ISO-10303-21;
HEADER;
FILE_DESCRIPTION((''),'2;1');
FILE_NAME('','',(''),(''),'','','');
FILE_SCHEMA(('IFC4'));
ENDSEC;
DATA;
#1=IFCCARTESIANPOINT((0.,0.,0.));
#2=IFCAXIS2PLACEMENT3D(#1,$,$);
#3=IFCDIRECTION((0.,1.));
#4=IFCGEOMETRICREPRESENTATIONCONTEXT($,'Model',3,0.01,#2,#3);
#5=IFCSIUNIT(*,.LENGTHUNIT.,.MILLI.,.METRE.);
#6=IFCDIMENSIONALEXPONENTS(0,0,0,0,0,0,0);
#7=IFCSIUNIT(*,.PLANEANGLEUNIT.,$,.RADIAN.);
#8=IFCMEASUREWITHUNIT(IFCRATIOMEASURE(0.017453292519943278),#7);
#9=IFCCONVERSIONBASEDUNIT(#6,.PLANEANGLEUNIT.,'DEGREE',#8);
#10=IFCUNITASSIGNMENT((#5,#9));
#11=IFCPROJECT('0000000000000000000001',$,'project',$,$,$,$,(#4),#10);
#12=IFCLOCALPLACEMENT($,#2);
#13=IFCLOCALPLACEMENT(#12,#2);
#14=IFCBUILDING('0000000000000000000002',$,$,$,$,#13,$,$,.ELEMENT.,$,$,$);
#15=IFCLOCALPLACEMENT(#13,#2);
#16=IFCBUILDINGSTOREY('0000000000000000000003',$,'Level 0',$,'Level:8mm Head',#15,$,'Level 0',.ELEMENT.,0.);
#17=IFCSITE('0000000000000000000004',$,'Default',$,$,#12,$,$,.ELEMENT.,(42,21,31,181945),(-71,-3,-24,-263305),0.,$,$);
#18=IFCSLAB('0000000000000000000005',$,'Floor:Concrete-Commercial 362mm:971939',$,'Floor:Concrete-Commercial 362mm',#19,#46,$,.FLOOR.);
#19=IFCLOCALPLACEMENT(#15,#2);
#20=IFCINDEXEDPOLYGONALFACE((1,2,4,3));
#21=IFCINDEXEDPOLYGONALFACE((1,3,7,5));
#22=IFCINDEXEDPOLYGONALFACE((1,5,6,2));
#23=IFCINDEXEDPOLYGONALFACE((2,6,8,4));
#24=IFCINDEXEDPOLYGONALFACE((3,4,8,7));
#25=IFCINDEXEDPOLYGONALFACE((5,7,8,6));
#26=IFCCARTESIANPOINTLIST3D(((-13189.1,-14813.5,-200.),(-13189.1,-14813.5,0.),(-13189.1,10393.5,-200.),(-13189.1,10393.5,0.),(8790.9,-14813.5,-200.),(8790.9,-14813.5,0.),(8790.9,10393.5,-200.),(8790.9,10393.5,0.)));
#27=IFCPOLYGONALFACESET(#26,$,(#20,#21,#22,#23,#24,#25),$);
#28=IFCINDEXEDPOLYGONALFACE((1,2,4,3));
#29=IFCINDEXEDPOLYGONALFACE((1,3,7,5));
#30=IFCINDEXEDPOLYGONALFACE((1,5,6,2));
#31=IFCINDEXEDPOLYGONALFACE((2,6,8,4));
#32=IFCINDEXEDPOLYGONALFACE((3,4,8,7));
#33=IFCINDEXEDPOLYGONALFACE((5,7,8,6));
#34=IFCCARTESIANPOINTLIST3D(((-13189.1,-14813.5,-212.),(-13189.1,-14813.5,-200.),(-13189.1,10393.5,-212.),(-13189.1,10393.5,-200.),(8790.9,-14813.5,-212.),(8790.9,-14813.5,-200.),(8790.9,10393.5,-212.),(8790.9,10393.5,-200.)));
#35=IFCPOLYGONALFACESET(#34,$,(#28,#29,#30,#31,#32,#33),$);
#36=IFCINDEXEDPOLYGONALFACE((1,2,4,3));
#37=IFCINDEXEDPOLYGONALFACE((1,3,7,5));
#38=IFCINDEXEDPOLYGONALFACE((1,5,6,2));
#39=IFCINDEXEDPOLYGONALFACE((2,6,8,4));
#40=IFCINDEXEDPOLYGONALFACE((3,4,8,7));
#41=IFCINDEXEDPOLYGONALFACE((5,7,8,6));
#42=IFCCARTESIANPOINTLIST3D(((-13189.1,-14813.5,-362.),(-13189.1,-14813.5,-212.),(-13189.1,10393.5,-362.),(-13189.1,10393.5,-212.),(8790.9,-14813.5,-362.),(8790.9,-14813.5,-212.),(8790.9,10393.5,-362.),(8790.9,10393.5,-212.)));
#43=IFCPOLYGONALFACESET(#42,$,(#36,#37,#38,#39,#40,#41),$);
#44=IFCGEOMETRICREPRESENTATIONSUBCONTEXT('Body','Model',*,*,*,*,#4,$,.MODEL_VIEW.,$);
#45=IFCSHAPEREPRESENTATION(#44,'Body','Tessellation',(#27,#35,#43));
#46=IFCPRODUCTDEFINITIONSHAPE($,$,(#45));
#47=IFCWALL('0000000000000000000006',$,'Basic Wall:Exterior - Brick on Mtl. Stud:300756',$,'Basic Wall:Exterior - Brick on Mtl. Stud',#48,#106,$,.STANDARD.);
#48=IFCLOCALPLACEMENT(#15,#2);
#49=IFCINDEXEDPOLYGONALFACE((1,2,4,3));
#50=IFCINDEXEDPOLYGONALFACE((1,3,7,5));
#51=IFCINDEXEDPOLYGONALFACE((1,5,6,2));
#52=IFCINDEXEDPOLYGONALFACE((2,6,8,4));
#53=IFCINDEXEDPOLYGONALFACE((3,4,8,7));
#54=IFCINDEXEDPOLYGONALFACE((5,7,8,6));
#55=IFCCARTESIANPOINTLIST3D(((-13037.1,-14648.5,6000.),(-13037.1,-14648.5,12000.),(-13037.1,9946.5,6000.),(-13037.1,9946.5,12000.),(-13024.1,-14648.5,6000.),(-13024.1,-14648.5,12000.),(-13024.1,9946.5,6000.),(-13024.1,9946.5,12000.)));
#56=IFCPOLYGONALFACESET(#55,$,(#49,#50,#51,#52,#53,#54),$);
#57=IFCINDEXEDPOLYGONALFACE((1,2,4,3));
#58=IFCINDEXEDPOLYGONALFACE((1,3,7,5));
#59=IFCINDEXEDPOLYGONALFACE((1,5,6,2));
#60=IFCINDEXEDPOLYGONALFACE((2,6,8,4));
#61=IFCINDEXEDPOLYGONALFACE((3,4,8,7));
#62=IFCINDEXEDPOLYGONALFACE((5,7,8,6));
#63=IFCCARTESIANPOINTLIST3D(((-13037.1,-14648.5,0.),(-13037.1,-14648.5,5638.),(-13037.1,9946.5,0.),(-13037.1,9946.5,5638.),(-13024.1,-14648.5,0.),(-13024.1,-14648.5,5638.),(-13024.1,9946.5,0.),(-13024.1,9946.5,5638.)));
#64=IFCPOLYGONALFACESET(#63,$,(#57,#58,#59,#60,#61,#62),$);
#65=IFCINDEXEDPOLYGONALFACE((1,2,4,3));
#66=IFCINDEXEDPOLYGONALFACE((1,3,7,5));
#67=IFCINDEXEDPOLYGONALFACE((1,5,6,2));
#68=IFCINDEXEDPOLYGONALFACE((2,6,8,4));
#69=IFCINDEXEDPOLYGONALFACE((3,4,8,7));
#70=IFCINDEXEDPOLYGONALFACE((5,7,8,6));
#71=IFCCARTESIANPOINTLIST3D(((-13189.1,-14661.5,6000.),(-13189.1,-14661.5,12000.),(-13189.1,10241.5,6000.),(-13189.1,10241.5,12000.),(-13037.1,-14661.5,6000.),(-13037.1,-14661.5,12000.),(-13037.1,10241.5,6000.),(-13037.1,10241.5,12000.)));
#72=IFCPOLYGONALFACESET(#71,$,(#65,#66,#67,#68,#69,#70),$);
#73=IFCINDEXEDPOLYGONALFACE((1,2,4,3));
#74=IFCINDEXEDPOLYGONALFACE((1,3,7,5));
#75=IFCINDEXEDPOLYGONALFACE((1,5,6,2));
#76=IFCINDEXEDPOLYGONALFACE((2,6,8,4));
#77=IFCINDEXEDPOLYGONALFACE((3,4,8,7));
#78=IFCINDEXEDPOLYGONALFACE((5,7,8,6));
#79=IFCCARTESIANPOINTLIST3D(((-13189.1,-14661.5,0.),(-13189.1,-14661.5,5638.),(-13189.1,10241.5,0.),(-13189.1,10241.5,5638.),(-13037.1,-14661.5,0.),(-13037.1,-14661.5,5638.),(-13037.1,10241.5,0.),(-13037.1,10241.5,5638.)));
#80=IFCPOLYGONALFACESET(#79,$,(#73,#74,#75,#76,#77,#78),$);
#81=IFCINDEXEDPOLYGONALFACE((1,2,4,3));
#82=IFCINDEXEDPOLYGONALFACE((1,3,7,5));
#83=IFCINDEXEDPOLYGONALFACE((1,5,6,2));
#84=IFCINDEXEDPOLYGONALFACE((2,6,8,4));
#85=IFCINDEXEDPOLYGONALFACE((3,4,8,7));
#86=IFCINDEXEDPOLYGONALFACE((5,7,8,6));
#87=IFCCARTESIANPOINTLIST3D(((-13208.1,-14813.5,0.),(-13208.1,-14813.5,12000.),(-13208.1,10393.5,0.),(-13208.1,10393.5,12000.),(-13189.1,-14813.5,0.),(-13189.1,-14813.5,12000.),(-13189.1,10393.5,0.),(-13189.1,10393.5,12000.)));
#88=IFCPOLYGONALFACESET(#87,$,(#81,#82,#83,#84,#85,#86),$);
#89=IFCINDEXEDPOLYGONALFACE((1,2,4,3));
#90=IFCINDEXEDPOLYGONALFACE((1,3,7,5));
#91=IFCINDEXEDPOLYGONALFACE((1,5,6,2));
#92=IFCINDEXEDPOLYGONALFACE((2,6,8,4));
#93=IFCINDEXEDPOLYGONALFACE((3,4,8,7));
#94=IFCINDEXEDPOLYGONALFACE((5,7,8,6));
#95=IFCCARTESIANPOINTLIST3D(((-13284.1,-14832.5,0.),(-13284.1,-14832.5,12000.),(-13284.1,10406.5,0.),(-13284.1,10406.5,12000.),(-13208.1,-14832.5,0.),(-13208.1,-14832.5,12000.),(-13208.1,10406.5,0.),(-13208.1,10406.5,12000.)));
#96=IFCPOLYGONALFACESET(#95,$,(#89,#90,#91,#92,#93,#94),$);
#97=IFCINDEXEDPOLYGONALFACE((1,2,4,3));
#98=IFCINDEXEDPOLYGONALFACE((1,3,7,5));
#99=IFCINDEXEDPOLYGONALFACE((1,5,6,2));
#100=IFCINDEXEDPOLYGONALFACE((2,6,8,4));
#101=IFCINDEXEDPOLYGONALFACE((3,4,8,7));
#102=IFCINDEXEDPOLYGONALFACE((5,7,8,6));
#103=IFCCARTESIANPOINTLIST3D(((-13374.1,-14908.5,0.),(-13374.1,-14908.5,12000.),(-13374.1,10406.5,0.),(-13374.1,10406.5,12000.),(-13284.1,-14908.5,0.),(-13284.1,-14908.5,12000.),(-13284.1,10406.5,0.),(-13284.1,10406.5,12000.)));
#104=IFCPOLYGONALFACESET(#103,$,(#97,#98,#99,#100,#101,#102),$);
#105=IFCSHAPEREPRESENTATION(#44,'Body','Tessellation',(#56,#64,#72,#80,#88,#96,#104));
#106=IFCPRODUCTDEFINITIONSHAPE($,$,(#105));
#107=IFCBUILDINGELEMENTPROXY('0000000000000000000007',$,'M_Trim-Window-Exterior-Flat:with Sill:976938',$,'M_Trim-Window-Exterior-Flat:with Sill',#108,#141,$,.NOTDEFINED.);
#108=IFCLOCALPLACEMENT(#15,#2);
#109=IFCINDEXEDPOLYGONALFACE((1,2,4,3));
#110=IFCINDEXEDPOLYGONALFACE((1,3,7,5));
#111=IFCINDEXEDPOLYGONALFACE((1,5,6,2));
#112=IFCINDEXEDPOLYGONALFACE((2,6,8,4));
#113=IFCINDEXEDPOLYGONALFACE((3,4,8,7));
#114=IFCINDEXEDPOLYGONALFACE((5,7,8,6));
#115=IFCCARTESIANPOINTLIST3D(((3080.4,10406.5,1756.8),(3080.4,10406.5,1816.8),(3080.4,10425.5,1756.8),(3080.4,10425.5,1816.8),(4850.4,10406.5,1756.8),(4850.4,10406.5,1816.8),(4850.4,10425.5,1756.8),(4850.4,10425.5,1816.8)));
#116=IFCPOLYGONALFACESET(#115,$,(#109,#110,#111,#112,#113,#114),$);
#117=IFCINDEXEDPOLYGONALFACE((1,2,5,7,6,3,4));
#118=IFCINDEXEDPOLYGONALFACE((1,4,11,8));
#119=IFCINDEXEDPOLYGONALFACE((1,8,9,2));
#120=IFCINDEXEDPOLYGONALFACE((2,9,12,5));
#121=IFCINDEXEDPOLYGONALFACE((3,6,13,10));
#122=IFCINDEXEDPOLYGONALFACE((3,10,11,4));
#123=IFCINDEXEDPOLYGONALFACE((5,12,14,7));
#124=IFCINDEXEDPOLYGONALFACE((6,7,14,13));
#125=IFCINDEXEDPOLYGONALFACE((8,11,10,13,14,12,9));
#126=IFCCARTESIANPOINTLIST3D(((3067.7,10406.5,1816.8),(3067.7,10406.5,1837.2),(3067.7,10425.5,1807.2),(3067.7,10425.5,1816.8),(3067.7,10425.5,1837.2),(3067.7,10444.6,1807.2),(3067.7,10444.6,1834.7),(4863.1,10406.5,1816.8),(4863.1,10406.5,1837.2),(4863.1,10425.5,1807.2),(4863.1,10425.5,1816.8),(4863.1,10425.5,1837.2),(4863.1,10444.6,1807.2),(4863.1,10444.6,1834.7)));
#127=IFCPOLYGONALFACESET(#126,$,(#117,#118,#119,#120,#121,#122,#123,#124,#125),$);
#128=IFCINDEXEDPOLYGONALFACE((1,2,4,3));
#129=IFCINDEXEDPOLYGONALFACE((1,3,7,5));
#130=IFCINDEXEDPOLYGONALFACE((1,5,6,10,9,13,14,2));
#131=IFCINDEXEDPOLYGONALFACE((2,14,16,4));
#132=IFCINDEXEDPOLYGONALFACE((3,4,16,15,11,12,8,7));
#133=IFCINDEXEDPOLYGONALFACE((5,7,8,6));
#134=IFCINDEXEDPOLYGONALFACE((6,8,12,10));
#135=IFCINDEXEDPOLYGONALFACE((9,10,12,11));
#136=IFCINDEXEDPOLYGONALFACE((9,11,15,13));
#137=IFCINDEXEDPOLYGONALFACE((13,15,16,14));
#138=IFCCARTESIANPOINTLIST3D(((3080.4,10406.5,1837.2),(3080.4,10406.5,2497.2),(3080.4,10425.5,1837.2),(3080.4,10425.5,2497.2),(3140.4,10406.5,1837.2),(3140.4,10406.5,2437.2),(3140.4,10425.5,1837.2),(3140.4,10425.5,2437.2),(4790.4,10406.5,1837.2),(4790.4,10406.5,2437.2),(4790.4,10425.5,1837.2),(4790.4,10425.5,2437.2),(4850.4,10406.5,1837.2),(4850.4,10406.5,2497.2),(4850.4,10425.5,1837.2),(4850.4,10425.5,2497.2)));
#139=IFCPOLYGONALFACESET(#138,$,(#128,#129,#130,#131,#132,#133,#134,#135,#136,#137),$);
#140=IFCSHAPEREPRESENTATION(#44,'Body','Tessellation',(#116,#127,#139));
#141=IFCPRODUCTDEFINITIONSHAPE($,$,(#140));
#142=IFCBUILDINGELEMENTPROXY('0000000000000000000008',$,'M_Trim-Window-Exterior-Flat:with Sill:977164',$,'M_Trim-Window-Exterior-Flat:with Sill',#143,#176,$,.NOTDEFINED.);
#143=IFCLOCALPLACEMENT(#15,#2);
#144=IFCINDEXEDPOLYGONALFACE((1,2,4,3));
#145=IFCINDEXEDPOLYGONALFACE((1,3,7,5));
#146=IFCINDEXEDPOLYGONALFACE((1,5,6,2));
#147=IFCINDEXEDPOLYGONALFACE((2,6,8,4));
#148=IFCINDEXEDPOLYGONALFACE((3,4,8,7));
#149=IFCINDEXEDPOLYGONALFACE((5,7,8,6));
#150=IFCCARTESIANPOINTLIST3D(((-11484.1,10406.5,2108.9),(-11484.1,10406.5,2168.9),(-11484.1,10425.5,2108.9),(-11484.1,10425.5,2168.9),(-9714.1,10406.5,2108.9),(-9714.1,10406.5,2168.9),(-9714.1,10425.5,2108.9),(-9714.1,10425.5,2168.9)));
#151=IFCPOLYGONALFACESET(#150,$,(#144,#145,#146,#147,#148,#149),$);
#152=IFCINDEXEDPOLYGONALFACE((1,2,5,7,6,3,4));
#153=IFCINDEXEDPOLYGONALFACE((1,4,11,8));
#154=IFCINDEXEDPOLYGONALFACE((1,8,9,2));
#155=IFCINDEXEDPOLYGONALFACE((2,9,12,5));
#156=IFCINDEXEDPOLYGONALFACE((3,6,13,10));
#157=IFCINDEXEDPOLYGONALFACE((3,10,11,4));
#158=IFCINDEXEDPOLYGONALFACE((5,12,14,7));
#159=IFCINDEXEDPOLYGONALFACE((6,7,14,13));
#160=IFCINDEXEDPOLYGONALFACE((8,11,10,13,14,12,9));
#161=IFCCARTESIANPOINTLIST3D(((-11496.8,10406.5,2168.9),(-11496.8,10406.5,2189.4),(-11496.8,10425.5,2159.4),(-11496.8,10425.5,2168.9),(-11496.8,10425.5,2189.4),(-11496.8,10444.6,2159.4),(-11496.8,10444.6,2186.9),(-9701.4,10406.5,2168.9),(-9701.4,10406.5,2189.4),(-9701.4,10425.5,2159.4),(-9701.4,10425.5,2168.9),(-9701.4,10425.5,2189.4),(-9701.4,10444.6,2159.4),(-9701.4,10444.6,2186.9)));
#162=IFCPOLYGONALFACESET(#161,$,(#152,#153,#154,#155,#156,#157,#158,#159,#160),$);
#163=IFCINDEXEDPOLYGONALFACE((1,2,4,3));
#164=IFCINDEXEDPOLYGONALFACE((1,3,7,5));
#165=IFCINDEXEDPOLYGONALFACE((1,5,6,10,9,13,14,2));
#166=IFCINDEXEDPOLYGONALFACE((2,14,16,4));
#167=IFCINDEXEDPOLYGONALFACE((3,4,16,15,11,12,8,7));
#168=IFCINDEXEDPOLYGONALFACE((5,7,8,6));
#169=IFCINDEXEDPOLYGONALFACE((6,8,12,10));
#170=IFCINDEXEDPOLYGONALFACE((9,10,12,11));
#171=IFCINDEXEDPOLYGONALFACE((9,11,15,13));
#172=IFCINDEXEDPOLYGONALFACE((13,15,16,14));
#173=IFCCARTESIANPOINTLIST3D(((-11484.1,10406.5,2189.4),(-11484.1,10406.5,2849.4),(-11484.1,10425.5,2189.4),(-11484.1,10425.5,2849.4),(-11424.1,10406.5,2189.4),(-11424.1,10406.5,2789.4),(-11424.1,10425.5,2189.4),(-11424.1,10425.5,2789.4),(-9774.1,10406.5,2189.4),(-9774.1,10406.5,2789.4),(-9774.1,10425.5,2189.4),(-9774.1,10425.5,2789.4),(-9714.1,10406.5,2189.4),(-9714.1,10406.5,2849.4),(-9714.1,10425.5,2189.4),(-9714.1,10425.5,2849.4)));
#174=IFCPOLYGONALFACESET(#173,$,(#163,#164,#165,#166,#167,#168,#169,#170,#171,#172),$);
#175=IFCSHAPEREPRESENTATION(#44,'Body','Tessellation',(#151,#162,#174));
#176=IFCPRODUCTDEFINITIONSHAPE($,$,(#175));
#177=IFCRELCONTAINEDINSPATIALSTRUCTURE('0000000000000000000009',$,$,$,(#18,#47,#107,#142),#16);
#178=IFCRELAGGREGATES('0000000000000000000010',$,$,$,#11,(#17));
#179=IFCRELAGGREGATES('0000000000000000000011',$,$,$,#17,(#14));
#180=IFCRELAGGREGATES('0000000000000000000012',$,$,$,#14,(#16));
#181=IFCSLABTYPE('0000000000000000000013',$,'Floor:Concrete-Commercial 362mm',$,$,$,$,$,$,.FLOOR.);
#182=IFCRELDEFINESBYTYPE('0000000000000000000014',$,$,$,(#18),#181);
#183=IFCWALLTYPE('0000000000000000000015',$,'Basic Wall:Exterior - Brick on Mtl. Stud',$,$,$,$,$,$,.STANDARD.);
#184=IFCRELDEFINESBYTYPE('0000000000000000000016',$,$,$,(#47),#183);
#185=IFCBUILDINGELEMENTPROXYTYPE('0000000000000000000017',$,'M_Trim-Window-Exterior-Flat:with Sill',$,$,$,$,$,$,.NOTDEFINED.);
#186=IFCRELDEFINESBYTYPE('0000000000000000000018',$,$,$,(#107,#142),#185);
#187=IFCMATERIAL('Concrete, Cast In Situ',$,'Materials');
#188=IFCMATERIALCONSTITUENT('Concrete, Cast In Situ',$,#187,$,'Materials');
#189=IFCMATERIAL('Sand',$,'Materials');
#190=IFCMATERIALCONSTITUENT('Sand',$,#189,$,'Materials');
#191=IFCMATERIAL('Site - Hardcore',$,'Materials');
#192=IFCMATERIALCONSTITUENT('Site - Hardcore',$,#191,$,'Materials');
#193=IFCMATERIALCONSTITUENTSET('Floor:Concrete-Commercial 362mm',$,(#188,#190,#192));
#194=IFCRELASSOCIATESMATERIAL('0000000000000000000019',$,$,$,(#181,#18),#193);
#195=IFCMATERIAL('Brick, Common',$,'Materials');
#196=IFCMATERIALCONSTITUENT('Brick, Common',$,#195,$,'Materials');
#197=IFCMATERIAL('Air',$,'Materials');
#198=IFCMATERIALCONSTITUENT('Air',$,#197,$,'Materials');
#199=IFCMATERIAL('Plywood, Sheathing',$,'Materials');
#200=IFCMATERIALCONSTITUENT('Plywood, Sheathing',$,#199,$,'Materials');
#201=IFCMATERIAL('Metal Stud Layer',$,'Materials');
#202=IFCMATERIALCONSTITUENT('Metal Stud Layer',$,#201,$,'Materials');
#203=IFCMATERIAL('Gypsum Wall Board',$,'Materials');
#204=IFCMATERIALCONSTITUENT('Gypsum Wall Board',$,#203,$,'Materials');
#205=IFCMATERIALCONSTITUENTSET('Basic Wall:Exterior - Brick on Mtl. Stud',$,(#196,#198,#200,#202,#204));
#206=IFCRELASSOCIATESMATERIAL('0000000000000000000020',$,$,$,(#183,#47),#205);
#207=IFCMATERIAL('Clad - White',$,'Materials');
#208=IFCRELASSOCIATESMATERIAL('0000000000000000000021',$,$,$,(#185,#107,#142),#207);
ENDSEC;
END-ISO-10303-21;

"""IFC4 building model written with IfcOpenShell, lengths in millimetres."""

from ifc_helpers import new_model, entity, si_unit, converted_unit, direction, frame, origin, place, context, subcontext, project, spatial, indexed_curve, outline, extrude, source, transform, mapped, material, constituent, constituent_set, type_object, type_shapes, element, save


model = new_model("IFC4")

# Units and contexts
model_context = context("Model", 3, precision=0.01, world=origin(), true_north=direction((0.0, 1.0)))
body_context = subcontext(model_context, "Body", "Model", "MODEL_VIEW")
ifc_project = project(units=[si_unit("LENGTHUNIT", "METRE", prefix="MILLI"), converted_unit("PLANEANGLEUNIT", "DEGREE", entity("IfcRatioMeasure", 0.017453292519943278), si_unit("PLANEANGLEUNIT", "RADIAN"), dimensions=[0, 0, 0, 0, 0, 0, 0])], contexts=[model_context])

# Site, building, storey
site_placement = place(None, origin())
site = spatial("IfcSite", under=ifc_project, at=site_placement, Name="Default", CompositionType="ELEMENT", RefLatitude=(42, 21, 31, 181945), RefLongitude=(-71, -3, -24, -263305), RefElevation=0.0)
building_placement = place(site_placement, origin())
building = spatial("IfcBuilding", under=site, at=building_placement, CompositionType="ELEMENT")
storey_placement = place(building_placement, origin())
storey = spatial("IfcBuildingStorey", under=building, at=storey_placement, Name="Level 0", ObjectType="Level:8mm Head", LongName="Level 0", CompositionType="ELEMENT", Elevation=0.0)

# Slab
ifc_material_1 = material(Name="Concrete, Cast In Situ", Category="Materials")
ifc_constituent_1 = constituent(ifc_material_1, Name="Concrete, Cast In Situ", Category="Materials")
ifc_material_2 = material(Name="Sand", Category="Materials")
ifc_constituent_2 = constituent(ifc_material_2, Name="Sand", Category="Materials")
ifc_material_3 = material(Name="Site - Hardcore", Category="Materials")
ifc_constituent_3 = constituent(ifc_material_3, Name="Site - Hardcore", Category="Materials")
ifc_constituent_set_1 = constituent_set(constituents=[ifc_constituent_1, ifc_constituent_2, ifc_constituent_3], Name="Floor:Concrete-Commercial 362mm")
slab_type = type_object("IfcSlabType", Name="Floor:Concrete-Commercial 362mm", PredefinedType="FLOOR", material=ifc_constituent_set_1)
slab_placement = place(storey_placement, origin())
element("IfcSlab", 1, at=slab_placement, inside=storey, type_object=slab_type, material=ifc_constituent_set_1, Name="Floor:Concrete-Commercial 362mm:971939", ObjectType="Floor:Concrete-Commercial 362mm", PredefinedType="FLOOR", context=body_context, shape_type="SweptSolid", body=[
    extrude(outline(indexed_curve([(-10990.0, -12603.5), (10990.0, -12603.5), (10990.0, 12603.5), (-10990.0, 12603.5), (-10990.0, -12603.5)], self_intersect=False)), frame((-2199.1, -2210.0, -200.0), z_axis=(0.0, 0.0, 1.0), x_axis=(-1.0, 0.0, 0.0)), (0.0, 0.0, 1.0), 200.0),
    extrude(outline(indexed_curve([(-10990.0, -12603.5), (10990.0, -12603.5), (10990.0, 12603.5), (-10990.0, 12603.5), (-10990.0, -12603.5)], self_intersect=False)), frame((-2199.1, -2210.0, -212.0), z_axis=(0.0, 0.0, 1.0), x_axis=(-1.0, 0.0, 0.0)), (0.0, 0.0, 1.0), 12.0),
    extrude(outline(indexed_curve([(-10990.0, -12603.5), (10990.0, -12603.5), (10990.0, 12603.5), (-10990.0, 12603.5), (-10990.0, -12603.5)], self_intersect=False)), frame((-2199.1, -2210.0, -362.0), z_axis=(0.0, 0.0, 1.0), x_axis=(-1.0, 0.0, 0.0)), (0.0, 0.0, 1.0), 150.0),
])

# Shared definitions
ifc_material_4 = material(Name="Air", Category="Materials")
ifc_material_5 = material(Name="Plywood, Sheathing", Category="Materials")
ifc_material_6 = material(Name="Metal Stud Layer", Category="Materials")
ifc_material_7 = material(Name="Gypsum Wall Board", Category="Materials")
ifc_material_8 = material(Name="Brick, Common", Category="Materials")
ifc_constituent_4 = constituent(ifc_material_8, Name="Brick, Common", Category="Materials")
ifc_constituent_5 = constituent(ifc_material_4, Name="Air", Category="Materials")
ifc_constituent_6 = constituent(ifc_material_5, Name="Plywood, Sheathing", Category="Materials")
ifc_constituent_7 = constituent(ifc_material_6, Name="Metal Stud Layer", Category="Materials")
ifc_constituent_8 = constituent(ifc_material_7, Name="Gypsum Wall Board", Category="Materials")
ifc_constituent_set_2 = constituent_set(constituents=[ifc_constituent_4, ifc_constituent_5, ifc_constituent_6, ifc_constituent_7, ifc_constituent_8], Name="Basic Wall:Exterior - Brick on Mtl. Stud")
wall_type_1 = type_object("IfcWallType", Name="Basic Wall:Exterior - Brick on Mtl. Stud", PredefinedType="STANDARD", material=ifc_constituent_set_2)

# Wall
wall_1_placement = place(storey_placement, frame((-13199.1, -14648.5, 0.0), z_axis=(0.0, 0.0, 1.0), x_axis=(0.0, 1.0, 0.0)))
element("IfcWall", 2, at=wall_1_placement, inside=storey, type_object=wall_type_1, material=ifc_constituent_set_2, Name="Basic Wall:Exterior - Brick on Mtl. Stud:300756", ObjectType="Basic Wall:Exterior - Brick on Mtl. Stud", PredefinedType="STANDARD", context=body_context, shape_type="SweptSolid", body=[
    extrude(outline(indexed_curve([(-3000.0, -12297.5), (3000.0, -12297.5), (3000.0, 12297.5), (-3000.0, 12297.5), (-3000.0, -12297.5)], self_intersect=False)), frame((12297.5, -162.0, 9000.0), z_axis=(0.0, -1.0, 0.0), x_axis=(0.0, 0.0, -1.0)), (0.0, 0.0, 1.0), 13.0),
    extrude(outline(indexed_curve([(-2819.0, -12297.5), (2819.0, -12297.5), (2819.0, 12297.5), (-2819.0, 12297.5), (-2819.0, -12297.5)], self_intersect=False)), frame((12297.5, -162.0, 2819.0), z_axis=(0.0, -1.0, 0.0), x_axis=(0.0, 0.0, 1.0)), (0.0, 0.0, 1.0), 13.0),
    extrude(outline(indexed_curve([(-3000.0, -12451.5), (3000.0, -12451.5), (3000.0, 12451.5), (-3000.0, 12451.5), (-3000.0, -12451.5)], self_intersect=False)), frame((12438.5, -10.0, 9000.0), z_axis=(0.0, -1.0, 0.0), x_axis=(0.0, 0.0, -1.0)), (0.0, 0.0, 1.0), 152.0),
    extrude(outline(indexed_curve([(-2819.0, -12451.5), (2819.0, -12451.5), (2819.0, 12451.5), (-2819.0, 12451.5), (-2819.0, -12451.5)], self_intersect=False)), frame((12438.5, -10.0, 2819.0), z_axis=(0.0, -1.0, 0.0), x_axis=(0.0, 0.0, 1.0)), (0.0, 0.0, 1.0), 152.0),
    extrude(outline(indexed_curve([(-12603.5, -9.5), (12603.5, -9.5), (12603.5, 9.5), (-12603.5, 9.5), (-12603.5, -9.5)], self_intersect=False)), frame((12438.5, -0.5, 0.0)), (0.0, 0.0, 1.0), 12000.0),
    extrude(outline(indexed_curve([(-12619.5, -38.0), (12619.5, -38.0), (12619.5, 38.0), (-12619.5, 38.0), (-12619.5, -38.0)], self_intersect=False)), frame((12435.5, 47.0, 0.0)), (0.0, 0.0, 1.0), 12000.0),
    extrude(outline(indexed_curve([(-45.0, -12657.5), (45.0, -12657.5), (45.0, 12657.5), (-45.0, 12657.5), (-45.0, -12657.5)], self_intersect=False)), frame((12397.5, 130.0, 0.0), z_axis=(0.0, 0.0, 1.0), x_axis=(0.0, -1.0, 0.0)), (0.0, 0.0, 1.0), 12000.0),
])

# Building element proxies
ifc_material_9 = material(Name="Clad - White", Category="Materials")
building_element_proxy_type_1 = type_object("IfcBuildingElementProxyType", Name="M_Trim-Window-Exterior-Flat:with Sill", PredefinedType="NOTDEFINED", material=ifc_material_9)
shared_shape_1 = source(origin(), body_context, "Body", "SweptSolid", [
    extrude(outline(indexed_curve([(-885.0, -30.0), (885.0, -30.0), (885.0, 30.0), (-885.0, 30.0), (-885.0, -30.0)], self_intersect=False)), frame((0.0, -650.4, 0.0), z_axis=(0.0, 0.0, 1.0), x_axis=(-1.0, 0.0, 0.0)), (0.0, 0.0, 1.0), 19.0),
    extrude(outline(indexed_curve([(-19.0, -15.2), (0.0, -15.2), (0.0, -5.7), (19.0, -5.7), (19.0, 14.8), (0.0, 14.8), (-19.0, 12.3), (-19.0, -15.2)], self_intersect=False)), frame((-897.7, -614.8, 19.0), z_axis=(1.0, 0.0, 0.0), x_axis=(0.0, 0.0, -1.0)), (0.0, 0.0, 1.0), 1795.4),
    extrude(outline(indexed_curve([(-345.0, -885.0), (315.0, -885.0), (315.0, -825.0), (-285.0, -825.0), (-285.0, 825.0), (315.0, 825.0), (315.0, 885.0), (-345.0, 885.0), (-345.0, -885.0)], self_intersect=False)), frame((0.0, -285.0, 0.0), z_axis=(0.0, 0.0, 1.0), x_axis=(0.0, -1.0, 0.0)), (0.0, 0.0, 1.0), 19.0),
])
type_shapes(building_element_proxy_type_1, [shared_shape_1])
for number, where, z_axis, x_axis, name in (
    (3, (3965.4, 10406.5, 2437.2), (0.0, 1.0, 0.0), (-1.0, 0.0, 0.0), "M_Trim-Window-Exterior-Flat:with Sill:976938"),
    (4, (-10599.1, 10406.5, 2789.4), (0.0, 1.0, 0.0), (-1.0, 0.0, 0.0), "M_Trim-Window-Exterior-Flat:with Sill:977164"),
):
    element("IfcBuildingElementProxy", number, at=place(storey_placement, frame(where, z_axis=z_axis, x_axis=x_axis)), inside=storey, type_object=building_element_proxy_type_1, material=ifc_material_9, Name=name, ObjectType="M_Trim-Window-Exterior-Flat:with Sill", PredefinedType="NOTDEFINED", context=body_context, shape_type="MappedRepresentation", body=[
        mapped(shared_shape_1, transform((0.0, 0.0, 0.0), scale=1.0)),
    ])

save(model, "model.ifc")
